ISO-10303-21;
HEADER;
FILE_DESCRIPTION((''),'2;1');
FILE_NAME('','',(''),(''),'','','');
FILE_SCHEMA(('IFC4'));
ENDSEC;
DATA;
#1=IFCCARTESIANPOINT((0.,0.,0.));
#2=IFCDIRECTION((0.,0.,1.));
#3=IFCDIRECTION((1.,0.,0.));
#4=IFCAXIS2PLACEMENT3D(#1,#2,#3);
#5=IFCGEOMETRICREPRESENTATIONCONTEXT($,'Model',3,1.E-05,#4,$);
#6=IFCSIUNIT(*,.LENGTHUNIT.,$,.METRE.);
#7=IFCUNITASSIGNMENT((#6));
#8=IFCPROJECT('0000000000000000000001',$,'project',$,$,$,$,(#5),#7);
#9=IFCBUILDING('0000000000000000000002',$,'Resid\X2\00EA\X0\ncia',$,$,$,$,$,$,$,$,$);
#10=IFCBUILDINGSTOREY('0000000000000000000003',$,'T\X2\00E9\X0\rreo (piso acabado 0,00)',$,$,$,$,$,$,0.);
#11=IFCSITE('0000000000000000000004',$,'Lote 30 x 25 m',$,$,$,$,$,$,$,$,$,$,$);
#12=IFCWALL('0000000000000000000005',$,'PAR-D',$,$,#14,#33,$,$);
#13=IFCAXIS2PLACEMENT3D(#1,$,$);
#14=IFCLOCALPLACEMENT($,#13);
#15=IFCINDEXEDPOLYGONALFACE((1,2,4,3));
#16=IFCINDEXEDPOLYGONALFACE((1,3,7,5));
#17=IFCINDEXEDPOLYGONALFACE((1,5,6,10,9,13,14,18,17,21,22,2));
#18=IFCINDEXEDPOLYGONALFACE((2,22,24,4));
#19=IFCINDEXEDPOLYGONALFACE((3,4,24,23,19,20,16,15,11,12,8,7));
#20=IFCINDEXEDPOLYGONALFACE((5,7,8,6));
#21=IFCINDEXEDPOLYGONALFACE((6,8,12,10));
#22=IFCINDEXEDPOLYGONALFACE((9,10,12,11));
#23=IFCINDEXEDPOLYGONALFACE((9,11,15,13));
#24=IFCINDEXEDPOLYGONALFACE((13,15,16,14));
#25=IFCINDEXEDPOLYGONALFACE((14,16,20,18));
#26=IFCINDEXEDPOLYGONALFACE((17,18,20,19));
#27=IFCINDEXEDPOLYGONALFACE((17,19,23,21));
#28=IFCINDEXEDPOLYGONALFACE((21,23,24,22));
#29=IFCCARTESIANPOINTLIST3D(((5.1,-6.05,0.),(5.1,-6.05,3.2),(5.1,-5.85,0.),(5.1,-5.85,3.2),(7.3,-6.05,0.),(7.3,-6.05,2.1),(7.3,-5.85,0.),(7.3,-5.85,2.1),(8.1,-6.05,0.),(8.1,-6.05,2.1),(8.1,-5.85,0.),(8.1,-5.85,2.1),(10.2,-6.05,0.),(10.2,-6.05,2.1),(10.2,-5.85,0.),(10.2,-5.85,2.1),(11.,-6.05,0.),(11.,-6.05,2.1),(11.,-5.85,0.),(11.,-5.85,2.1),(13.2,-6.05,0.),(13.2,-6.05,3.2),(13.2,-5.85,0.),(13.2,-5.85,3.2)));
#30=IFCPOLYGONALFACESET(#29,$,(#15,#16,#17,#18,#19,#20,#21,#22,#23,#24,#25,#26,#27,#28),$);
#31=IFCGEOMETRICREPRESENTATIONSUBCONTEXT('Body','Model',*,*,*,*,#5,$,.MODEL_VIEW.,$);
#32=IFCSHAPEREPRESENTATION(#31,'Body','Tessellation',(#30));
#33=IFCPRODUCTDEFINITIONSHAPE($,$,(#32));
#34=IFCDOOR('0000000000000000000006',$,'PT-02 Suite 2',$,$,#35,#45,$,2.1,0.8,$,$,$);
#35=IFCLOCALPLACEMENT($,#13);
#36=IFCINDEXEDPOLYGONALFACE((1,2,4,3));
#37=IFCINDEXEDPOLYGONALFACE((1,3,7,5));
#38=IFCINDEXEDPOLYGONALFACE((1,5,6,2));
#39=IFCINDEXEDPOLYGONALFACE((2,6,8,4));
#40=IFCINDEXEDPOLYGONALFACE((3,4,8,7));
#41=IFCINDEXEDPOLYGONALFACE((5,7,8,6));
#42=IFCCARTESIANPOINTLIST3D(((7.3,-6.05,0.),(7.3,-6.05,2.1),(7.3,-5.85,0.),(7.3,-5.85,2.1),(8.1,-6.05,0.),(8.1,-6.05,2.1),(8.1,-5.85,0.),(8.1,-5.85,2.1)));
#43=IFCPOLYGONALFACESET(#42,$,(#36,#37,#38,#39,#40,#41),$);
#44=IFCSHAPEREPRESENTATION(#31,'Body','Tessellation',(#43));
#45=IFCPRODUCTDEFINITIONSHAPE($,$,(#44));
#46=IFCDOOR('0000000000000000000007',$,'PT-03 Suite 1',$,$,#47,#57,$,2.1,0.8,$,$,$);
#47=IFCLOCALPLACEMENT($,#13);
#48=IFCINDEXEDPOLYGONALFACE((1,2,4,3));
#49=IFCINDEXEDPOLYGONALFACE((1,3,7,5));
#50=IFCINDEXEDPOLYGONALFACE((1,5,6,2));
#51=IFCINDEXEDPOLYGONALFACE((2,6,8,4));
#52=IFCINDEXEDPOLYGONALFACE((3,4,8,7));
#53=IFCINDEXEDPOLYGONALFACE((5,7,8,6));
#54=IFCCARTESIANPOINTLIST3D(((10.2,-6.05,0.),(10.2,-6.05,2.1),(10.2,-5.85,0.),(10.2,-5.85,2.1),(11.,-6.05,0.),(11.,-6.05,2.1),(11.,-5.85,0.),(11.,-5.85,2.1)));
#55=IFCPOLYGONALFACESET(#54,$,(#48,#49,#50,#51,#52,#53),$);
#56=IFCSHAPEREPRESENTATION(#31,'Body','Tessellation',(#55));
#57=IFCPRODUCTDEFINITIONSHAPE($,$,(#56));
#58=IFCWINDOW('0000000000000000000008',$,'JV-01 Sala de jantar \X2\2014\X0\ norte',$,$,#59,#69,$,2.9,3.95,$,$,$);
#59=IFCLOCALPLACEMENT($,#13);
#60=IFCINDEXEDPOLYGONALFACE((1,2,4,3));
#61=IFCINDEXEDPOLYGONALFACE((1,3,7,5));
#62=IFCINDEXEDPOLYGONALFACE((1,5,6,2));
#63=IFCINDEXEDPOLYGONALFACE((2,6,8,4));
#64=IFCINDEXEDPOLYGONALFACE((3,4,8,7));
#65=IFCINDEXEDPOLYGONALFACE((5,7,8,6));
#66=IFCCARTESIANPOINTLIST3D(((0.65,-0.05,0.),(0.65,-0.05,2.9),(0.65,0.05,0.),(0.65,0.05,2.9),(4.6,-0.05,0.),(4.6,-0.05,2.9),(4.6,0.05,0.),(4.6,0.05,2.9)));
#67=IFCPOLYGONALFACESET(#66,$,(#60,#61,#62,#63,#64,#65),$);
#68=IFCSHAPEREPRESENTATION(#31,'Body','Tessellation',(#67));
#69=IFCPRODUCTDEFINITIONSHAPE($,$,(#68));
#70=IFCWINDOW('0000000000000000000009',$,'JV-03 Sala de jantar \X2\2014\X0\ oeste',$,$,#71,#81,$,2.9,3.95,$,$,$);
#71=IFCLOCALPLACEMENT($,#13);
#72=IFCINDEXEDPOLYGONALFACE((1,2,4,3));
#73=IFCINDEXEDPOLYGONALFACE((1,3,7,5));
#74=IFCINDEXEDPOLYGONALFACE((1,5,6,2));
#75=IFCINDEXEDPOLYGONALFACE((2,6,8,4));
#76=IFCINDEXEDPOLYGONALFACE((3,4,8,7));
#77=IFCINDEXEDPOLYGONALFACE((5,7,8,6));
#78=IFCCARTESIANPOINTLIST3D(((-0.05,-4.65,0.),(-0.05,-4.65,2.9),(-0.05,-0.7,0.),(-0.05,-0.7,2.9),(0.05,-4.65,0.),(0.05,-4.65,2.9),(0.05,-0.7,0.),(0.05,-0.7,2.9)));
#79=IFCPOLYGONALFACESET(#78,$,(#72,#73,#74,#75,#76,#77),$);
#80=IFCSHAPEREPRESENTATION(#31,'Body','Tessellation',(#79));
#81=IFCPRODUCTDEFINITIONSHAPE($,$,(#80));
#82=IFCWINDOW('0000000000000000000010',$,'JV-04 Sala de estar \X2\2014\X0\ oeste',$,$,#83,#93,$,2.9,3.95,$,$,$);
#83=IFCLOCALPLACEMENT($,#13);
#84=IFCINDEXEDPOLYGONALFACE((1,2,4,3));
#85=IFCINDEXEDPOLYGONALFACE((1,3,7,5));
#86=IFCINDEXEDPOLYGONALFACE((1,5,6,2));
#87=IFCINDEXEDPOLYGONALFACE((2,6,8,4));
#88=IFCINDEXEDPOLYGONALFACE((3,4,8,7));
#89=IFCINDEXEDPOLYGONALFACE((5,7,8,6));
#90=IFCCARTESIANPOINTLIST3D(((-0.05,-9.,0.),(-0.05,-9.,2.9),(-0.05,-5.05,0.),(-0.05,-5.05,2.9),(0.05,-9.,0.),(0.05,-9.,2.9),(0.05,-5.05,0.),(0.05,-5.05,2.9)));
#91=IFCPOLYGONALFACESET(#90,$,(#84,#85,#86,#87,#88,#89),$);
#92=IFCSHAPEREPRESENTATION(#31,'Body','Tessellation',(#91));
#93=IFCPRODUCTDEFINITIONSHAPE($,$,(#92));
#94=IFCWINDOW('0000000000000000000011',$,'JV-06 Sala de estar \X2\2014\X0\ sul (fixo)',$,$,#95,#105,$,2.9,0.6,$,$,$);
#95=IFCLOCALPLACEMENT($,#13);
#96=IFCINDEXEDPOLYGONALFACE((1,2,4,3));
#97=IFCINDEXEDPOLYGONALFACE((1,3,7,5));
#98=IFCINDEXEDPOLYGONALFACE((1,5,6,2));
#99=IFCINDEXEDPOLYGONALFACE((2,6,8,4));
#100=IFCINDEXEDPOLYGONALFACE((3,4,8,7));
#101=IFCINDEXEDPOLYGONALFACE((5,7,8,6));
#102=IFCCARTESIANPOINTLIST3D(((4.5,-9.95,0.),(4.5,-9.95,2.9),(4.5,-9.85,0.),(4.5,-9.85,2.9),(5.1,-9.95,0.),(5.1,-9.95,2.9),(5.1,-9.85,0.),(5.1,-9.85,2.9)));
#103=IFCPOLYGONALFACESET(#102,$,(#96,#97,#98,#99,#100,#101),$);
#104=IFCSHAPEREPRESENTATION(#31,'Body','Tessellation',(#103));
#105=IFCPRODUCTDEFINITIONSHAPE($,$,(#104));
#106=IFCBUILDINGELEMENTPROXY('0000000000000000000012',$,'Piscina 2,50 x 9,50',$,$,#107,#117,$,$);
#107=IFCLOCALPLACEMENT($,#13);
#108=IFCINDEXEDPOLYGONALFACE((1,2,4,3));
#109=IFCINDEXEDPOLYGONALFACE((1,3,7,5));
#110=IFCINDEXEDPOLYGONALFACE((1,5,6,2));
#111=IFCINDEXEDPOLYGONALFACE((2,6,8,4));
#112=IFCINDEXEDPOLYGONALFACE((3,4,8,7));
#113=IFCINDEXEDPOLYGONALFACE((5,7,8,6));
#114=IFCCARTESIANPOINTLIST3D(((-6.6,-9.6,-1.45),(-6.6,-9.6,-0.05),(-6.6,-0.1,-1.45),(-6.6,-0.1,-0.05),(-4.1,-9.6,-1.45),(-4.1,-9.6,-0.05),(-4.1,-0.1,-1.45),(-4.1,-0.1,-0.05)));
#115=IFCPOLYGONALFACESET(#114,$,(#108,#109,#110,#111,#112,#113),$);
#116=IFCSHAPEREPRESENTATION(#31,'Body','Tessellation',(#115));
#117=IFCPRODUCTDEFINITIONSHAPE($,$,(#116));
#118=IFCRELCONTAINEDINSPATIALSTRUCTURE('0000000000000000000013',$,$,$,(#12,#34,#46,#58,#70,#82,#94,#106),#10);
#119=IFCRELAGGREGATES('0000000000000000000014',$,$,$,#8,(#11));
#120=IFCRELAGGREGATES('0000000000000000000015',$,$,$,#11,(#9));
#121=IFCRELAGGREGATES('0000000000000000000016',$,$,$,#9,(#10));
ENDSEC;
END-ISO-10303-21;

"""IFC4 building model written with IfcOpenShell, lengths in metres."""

from ifc_helpers import new_model, si_unit, frame, origin_with_axes, place, context, subcontext, project, spatial, line, indexed_curve, outline, extrude, element, fill, save


model = new_model("IFC4")

# Units and contexts
model_context = context("Model", 3, precision=1e-05, world=origin_with_axes())
body_context = subcontext(model_context, "Body", "Model", "MODEL_VIEW")
ifc_project = project(units=[si_unit("LENGTHUNIT", "METRE")], contexts=[model_context])

# Site, building, storey
site = spatial("IfcSite", under=ifc_project, Name="Lote 30 x 25 m")
building = spatial("IfcBuilding", under=site, Name="Residência")
storey = spatial("IfcBuildingStorey", under=building, Name="Térreo (piso acabado 0,00)", Elevation=0.0)

# Wall, openings, doors
wall_1_placement = place(None, frame((5.1, -6.05, 0.0), z_axis=(0.0, 0.0, 1.0), x_axis=(1.0, 0.0, 0.0)))
wall_1 = element("IfcWall", 1, at=wall_1_placement, inside=storey, Name="PAR-D", context=body_context, shape_type="SweptSolid", body=[
    extrude(outline(indexed_curve([(0.0, 0.0), (8.1, 0.0), (8.1, 0.2), (0.0, 0.2)], segments=[line(1, 2, 3, 4, 1)])), origin_with_axes(), (0.0, 0.0, 1.0), 3.2),
])
opening_1_placement = place(wall_1_placement, frame((2.2, -0.01, 0.0), z_axis=(0.0, 0.0, 1.0), x_axis=(1.0, 0.0, 0.0)))
opening_1 = element("IfcOpeningElement", 2, at=opening_1_placement, cuts=wall_1, context=body_context, shape_type="SweptSolid", body=[
    extrude(outline(indexed_curve([(0.0, 0.0), (0.8, 0.0), (0.8, 0.22), (0.0, 0.22)], segments=[line(1, 2, 3, 4, 1)])), origin_with_axes(), (0.0, 0.0, 1.0), 2.1),
])
opening_2_placement = place(wall_1_placement, frame((5.1, -0.01, 0.0), z_axis=(0.0, 0.0, 1.0), x_axis=(1.0, 0.0, 0.0)))
opening_2 = element("IfcOpeningElement", 3, at=opening_2_placement, cuts=wall_1, context=body_context, shape_type="SweptSolid", body=[
    extrude(outline(indexed_curve([(0.0, 0.0), (0.8, 0.0), (0.8, 0.22), (0.0, 0.22)], segments=[line(1, 2, 3, 4, 1)])), origin_with_axes(), (0.0, 0.0, 1.0), 2.1),
])
door_1_placement = place(None, frame((7.3, -6.05, 0.0), z_axis=(0.0, 0.0, 1.0), x_axis=(1.0, 0.0, 0.0)))
door_1 = element("IfcDoor", 4, at=door_1_placement, inside=storey, Name="PT-02 Suite 2", OverallHeight=2.1, OverallWidth=0.8, context=body_context, shape_type="SweptSolid", body=[
    extrude(outline(indexed_curve([(0.0, 0.0), (0.8, 0.0), (0.8, 0.2), (0.0, 0.2)], segments=[line(1, 2, 3, 4, 1)])), origin_with_axes(), (0.0, 0.0, 1.0), 2.1),
])
fill(opening_1, door_1)
door_2_placement = place(None, frame((10.2, -6.05, 0.0), z_axis=(0.0, 0.0, 1.0), x_axis=(1.0, 0.0, 0.0)))
door_2 = element("IfcDoor", 5, at=door_2_placement, inside=storey, Name="PT-03 Suite 1", OverallHeight=2.1, OverallWidth=0.8, context=body_context, shape_type="SweptSolid", body=[
    extrude(outline(indexed_curve([(0.0, 0.0), (0.8, 0.0), (0.8, 0.2), (0.0, 0.2)], segments=[line(1, 2, 3, 4, 1)])), origin_with_axes(), (0.0, 0.0, 1.0), 2.1),
])
fill(opening_2, door_2)

# Windows
window_1_placement = place(None, frame((0.65, -0.05, 0.0), z_axis=(0.0, 0.0, 1.0), x_axis=(1.0, 0.0, 0.0)))
element("IfcWindow", 6, at=window_1_placement, inside=storey, Name="JV-01 Sala de jantar — norte", OverallHeight=2.9, OverallWidth=3.95, context=body_context, shape_type="SweptSolid", body=[
    extrude(outline(indexed_curve([(0.0, 0.0), (3.95, 0.0), (3.95, 0.1), (0.0, 0.1)], segments=[line(1, 2, 3, 4, 1)])), origin_with_axes(), (0.0, 0.0, 1.0), 2.9),
])
for number, where, z_axis, x_axis, name in (
    (7, (-0.05, -4.65, 0.0), (0.0, 0.0, 1.0), (1.0, 0.0, 0.0), "JV-03 Sala de jantar — oeste"),
    (8, (-0.05, -9.0, 0.0), (0.0, 0.0, 1.0), (1.0, 0.0, 0.0), "JV-04 Sala de estar — oeste"),
):
    element("IfcWindow", number, at=place(None, frame(where, z_axis=z_axis, x_axis=x_axis)), inside=storey, Name=name, OverallHeight=2.9, OverallWidth=3.95, context=body_context, shape_type="SweptSolid", body=[
        extrude(outline(indexed_curve([(0.0, 0.0), (0.1, 0.0), (0.1, 3.95), (0.0, 3.95)], segments=[line(1, 2, 3, 4, 1)])), origin_with_axes(), (0.0, 0.0, 1.0), 2.9),
    ])
window_2_placement = place(None, frame((4.5, -9.95, 0.0), z_axis=(0.0, 0.0, 1.0), x_axis=(1.0, 0.0, 0.0)))
element("IfcWindow", 9, at=window_2_placement, inside=storey, Name="JV-06 Sala de estar — sul (fixo)", OverallHeight=2.9, OverallWidth=0.6, context=body_context, shape_type="SweptSolid", body=[
    extrude(outline(indexed_curve([(0.0, 0.0), (0.6, 0.0), (0.6, 0.1), (0.0, 0.1)], segments=[line(1, 2, 3, 4, 1)])), origin_with_axes(), (0.0, 0.0, 1.0), 2.9),
])

# Building element proxy
proxy_placement = place(None, frame((-6.6, -9.6, -1.45), z_axis=(0.0, 0.0, 1.0), x_axis=(1.0, 0.0, 0.0)))
element("IfcBuildingElementProxy", 10, at=proxy_placement, inside=storey, Name="Piscina 2,50 x 9,50", context=body_context, shape_type="SweptSolid", body=[
    extrude(outline(indexed_curve([(0.0, 0.0), (2.5, 0.0), (2.5, 9.5), (0.0, 9.5)], segments=[line(1, 2, 3, 4, 1)])), origin_with_axes(), (0.0, 0.0, 1.0), 1.4),
])

save(model, "model.ifc")
